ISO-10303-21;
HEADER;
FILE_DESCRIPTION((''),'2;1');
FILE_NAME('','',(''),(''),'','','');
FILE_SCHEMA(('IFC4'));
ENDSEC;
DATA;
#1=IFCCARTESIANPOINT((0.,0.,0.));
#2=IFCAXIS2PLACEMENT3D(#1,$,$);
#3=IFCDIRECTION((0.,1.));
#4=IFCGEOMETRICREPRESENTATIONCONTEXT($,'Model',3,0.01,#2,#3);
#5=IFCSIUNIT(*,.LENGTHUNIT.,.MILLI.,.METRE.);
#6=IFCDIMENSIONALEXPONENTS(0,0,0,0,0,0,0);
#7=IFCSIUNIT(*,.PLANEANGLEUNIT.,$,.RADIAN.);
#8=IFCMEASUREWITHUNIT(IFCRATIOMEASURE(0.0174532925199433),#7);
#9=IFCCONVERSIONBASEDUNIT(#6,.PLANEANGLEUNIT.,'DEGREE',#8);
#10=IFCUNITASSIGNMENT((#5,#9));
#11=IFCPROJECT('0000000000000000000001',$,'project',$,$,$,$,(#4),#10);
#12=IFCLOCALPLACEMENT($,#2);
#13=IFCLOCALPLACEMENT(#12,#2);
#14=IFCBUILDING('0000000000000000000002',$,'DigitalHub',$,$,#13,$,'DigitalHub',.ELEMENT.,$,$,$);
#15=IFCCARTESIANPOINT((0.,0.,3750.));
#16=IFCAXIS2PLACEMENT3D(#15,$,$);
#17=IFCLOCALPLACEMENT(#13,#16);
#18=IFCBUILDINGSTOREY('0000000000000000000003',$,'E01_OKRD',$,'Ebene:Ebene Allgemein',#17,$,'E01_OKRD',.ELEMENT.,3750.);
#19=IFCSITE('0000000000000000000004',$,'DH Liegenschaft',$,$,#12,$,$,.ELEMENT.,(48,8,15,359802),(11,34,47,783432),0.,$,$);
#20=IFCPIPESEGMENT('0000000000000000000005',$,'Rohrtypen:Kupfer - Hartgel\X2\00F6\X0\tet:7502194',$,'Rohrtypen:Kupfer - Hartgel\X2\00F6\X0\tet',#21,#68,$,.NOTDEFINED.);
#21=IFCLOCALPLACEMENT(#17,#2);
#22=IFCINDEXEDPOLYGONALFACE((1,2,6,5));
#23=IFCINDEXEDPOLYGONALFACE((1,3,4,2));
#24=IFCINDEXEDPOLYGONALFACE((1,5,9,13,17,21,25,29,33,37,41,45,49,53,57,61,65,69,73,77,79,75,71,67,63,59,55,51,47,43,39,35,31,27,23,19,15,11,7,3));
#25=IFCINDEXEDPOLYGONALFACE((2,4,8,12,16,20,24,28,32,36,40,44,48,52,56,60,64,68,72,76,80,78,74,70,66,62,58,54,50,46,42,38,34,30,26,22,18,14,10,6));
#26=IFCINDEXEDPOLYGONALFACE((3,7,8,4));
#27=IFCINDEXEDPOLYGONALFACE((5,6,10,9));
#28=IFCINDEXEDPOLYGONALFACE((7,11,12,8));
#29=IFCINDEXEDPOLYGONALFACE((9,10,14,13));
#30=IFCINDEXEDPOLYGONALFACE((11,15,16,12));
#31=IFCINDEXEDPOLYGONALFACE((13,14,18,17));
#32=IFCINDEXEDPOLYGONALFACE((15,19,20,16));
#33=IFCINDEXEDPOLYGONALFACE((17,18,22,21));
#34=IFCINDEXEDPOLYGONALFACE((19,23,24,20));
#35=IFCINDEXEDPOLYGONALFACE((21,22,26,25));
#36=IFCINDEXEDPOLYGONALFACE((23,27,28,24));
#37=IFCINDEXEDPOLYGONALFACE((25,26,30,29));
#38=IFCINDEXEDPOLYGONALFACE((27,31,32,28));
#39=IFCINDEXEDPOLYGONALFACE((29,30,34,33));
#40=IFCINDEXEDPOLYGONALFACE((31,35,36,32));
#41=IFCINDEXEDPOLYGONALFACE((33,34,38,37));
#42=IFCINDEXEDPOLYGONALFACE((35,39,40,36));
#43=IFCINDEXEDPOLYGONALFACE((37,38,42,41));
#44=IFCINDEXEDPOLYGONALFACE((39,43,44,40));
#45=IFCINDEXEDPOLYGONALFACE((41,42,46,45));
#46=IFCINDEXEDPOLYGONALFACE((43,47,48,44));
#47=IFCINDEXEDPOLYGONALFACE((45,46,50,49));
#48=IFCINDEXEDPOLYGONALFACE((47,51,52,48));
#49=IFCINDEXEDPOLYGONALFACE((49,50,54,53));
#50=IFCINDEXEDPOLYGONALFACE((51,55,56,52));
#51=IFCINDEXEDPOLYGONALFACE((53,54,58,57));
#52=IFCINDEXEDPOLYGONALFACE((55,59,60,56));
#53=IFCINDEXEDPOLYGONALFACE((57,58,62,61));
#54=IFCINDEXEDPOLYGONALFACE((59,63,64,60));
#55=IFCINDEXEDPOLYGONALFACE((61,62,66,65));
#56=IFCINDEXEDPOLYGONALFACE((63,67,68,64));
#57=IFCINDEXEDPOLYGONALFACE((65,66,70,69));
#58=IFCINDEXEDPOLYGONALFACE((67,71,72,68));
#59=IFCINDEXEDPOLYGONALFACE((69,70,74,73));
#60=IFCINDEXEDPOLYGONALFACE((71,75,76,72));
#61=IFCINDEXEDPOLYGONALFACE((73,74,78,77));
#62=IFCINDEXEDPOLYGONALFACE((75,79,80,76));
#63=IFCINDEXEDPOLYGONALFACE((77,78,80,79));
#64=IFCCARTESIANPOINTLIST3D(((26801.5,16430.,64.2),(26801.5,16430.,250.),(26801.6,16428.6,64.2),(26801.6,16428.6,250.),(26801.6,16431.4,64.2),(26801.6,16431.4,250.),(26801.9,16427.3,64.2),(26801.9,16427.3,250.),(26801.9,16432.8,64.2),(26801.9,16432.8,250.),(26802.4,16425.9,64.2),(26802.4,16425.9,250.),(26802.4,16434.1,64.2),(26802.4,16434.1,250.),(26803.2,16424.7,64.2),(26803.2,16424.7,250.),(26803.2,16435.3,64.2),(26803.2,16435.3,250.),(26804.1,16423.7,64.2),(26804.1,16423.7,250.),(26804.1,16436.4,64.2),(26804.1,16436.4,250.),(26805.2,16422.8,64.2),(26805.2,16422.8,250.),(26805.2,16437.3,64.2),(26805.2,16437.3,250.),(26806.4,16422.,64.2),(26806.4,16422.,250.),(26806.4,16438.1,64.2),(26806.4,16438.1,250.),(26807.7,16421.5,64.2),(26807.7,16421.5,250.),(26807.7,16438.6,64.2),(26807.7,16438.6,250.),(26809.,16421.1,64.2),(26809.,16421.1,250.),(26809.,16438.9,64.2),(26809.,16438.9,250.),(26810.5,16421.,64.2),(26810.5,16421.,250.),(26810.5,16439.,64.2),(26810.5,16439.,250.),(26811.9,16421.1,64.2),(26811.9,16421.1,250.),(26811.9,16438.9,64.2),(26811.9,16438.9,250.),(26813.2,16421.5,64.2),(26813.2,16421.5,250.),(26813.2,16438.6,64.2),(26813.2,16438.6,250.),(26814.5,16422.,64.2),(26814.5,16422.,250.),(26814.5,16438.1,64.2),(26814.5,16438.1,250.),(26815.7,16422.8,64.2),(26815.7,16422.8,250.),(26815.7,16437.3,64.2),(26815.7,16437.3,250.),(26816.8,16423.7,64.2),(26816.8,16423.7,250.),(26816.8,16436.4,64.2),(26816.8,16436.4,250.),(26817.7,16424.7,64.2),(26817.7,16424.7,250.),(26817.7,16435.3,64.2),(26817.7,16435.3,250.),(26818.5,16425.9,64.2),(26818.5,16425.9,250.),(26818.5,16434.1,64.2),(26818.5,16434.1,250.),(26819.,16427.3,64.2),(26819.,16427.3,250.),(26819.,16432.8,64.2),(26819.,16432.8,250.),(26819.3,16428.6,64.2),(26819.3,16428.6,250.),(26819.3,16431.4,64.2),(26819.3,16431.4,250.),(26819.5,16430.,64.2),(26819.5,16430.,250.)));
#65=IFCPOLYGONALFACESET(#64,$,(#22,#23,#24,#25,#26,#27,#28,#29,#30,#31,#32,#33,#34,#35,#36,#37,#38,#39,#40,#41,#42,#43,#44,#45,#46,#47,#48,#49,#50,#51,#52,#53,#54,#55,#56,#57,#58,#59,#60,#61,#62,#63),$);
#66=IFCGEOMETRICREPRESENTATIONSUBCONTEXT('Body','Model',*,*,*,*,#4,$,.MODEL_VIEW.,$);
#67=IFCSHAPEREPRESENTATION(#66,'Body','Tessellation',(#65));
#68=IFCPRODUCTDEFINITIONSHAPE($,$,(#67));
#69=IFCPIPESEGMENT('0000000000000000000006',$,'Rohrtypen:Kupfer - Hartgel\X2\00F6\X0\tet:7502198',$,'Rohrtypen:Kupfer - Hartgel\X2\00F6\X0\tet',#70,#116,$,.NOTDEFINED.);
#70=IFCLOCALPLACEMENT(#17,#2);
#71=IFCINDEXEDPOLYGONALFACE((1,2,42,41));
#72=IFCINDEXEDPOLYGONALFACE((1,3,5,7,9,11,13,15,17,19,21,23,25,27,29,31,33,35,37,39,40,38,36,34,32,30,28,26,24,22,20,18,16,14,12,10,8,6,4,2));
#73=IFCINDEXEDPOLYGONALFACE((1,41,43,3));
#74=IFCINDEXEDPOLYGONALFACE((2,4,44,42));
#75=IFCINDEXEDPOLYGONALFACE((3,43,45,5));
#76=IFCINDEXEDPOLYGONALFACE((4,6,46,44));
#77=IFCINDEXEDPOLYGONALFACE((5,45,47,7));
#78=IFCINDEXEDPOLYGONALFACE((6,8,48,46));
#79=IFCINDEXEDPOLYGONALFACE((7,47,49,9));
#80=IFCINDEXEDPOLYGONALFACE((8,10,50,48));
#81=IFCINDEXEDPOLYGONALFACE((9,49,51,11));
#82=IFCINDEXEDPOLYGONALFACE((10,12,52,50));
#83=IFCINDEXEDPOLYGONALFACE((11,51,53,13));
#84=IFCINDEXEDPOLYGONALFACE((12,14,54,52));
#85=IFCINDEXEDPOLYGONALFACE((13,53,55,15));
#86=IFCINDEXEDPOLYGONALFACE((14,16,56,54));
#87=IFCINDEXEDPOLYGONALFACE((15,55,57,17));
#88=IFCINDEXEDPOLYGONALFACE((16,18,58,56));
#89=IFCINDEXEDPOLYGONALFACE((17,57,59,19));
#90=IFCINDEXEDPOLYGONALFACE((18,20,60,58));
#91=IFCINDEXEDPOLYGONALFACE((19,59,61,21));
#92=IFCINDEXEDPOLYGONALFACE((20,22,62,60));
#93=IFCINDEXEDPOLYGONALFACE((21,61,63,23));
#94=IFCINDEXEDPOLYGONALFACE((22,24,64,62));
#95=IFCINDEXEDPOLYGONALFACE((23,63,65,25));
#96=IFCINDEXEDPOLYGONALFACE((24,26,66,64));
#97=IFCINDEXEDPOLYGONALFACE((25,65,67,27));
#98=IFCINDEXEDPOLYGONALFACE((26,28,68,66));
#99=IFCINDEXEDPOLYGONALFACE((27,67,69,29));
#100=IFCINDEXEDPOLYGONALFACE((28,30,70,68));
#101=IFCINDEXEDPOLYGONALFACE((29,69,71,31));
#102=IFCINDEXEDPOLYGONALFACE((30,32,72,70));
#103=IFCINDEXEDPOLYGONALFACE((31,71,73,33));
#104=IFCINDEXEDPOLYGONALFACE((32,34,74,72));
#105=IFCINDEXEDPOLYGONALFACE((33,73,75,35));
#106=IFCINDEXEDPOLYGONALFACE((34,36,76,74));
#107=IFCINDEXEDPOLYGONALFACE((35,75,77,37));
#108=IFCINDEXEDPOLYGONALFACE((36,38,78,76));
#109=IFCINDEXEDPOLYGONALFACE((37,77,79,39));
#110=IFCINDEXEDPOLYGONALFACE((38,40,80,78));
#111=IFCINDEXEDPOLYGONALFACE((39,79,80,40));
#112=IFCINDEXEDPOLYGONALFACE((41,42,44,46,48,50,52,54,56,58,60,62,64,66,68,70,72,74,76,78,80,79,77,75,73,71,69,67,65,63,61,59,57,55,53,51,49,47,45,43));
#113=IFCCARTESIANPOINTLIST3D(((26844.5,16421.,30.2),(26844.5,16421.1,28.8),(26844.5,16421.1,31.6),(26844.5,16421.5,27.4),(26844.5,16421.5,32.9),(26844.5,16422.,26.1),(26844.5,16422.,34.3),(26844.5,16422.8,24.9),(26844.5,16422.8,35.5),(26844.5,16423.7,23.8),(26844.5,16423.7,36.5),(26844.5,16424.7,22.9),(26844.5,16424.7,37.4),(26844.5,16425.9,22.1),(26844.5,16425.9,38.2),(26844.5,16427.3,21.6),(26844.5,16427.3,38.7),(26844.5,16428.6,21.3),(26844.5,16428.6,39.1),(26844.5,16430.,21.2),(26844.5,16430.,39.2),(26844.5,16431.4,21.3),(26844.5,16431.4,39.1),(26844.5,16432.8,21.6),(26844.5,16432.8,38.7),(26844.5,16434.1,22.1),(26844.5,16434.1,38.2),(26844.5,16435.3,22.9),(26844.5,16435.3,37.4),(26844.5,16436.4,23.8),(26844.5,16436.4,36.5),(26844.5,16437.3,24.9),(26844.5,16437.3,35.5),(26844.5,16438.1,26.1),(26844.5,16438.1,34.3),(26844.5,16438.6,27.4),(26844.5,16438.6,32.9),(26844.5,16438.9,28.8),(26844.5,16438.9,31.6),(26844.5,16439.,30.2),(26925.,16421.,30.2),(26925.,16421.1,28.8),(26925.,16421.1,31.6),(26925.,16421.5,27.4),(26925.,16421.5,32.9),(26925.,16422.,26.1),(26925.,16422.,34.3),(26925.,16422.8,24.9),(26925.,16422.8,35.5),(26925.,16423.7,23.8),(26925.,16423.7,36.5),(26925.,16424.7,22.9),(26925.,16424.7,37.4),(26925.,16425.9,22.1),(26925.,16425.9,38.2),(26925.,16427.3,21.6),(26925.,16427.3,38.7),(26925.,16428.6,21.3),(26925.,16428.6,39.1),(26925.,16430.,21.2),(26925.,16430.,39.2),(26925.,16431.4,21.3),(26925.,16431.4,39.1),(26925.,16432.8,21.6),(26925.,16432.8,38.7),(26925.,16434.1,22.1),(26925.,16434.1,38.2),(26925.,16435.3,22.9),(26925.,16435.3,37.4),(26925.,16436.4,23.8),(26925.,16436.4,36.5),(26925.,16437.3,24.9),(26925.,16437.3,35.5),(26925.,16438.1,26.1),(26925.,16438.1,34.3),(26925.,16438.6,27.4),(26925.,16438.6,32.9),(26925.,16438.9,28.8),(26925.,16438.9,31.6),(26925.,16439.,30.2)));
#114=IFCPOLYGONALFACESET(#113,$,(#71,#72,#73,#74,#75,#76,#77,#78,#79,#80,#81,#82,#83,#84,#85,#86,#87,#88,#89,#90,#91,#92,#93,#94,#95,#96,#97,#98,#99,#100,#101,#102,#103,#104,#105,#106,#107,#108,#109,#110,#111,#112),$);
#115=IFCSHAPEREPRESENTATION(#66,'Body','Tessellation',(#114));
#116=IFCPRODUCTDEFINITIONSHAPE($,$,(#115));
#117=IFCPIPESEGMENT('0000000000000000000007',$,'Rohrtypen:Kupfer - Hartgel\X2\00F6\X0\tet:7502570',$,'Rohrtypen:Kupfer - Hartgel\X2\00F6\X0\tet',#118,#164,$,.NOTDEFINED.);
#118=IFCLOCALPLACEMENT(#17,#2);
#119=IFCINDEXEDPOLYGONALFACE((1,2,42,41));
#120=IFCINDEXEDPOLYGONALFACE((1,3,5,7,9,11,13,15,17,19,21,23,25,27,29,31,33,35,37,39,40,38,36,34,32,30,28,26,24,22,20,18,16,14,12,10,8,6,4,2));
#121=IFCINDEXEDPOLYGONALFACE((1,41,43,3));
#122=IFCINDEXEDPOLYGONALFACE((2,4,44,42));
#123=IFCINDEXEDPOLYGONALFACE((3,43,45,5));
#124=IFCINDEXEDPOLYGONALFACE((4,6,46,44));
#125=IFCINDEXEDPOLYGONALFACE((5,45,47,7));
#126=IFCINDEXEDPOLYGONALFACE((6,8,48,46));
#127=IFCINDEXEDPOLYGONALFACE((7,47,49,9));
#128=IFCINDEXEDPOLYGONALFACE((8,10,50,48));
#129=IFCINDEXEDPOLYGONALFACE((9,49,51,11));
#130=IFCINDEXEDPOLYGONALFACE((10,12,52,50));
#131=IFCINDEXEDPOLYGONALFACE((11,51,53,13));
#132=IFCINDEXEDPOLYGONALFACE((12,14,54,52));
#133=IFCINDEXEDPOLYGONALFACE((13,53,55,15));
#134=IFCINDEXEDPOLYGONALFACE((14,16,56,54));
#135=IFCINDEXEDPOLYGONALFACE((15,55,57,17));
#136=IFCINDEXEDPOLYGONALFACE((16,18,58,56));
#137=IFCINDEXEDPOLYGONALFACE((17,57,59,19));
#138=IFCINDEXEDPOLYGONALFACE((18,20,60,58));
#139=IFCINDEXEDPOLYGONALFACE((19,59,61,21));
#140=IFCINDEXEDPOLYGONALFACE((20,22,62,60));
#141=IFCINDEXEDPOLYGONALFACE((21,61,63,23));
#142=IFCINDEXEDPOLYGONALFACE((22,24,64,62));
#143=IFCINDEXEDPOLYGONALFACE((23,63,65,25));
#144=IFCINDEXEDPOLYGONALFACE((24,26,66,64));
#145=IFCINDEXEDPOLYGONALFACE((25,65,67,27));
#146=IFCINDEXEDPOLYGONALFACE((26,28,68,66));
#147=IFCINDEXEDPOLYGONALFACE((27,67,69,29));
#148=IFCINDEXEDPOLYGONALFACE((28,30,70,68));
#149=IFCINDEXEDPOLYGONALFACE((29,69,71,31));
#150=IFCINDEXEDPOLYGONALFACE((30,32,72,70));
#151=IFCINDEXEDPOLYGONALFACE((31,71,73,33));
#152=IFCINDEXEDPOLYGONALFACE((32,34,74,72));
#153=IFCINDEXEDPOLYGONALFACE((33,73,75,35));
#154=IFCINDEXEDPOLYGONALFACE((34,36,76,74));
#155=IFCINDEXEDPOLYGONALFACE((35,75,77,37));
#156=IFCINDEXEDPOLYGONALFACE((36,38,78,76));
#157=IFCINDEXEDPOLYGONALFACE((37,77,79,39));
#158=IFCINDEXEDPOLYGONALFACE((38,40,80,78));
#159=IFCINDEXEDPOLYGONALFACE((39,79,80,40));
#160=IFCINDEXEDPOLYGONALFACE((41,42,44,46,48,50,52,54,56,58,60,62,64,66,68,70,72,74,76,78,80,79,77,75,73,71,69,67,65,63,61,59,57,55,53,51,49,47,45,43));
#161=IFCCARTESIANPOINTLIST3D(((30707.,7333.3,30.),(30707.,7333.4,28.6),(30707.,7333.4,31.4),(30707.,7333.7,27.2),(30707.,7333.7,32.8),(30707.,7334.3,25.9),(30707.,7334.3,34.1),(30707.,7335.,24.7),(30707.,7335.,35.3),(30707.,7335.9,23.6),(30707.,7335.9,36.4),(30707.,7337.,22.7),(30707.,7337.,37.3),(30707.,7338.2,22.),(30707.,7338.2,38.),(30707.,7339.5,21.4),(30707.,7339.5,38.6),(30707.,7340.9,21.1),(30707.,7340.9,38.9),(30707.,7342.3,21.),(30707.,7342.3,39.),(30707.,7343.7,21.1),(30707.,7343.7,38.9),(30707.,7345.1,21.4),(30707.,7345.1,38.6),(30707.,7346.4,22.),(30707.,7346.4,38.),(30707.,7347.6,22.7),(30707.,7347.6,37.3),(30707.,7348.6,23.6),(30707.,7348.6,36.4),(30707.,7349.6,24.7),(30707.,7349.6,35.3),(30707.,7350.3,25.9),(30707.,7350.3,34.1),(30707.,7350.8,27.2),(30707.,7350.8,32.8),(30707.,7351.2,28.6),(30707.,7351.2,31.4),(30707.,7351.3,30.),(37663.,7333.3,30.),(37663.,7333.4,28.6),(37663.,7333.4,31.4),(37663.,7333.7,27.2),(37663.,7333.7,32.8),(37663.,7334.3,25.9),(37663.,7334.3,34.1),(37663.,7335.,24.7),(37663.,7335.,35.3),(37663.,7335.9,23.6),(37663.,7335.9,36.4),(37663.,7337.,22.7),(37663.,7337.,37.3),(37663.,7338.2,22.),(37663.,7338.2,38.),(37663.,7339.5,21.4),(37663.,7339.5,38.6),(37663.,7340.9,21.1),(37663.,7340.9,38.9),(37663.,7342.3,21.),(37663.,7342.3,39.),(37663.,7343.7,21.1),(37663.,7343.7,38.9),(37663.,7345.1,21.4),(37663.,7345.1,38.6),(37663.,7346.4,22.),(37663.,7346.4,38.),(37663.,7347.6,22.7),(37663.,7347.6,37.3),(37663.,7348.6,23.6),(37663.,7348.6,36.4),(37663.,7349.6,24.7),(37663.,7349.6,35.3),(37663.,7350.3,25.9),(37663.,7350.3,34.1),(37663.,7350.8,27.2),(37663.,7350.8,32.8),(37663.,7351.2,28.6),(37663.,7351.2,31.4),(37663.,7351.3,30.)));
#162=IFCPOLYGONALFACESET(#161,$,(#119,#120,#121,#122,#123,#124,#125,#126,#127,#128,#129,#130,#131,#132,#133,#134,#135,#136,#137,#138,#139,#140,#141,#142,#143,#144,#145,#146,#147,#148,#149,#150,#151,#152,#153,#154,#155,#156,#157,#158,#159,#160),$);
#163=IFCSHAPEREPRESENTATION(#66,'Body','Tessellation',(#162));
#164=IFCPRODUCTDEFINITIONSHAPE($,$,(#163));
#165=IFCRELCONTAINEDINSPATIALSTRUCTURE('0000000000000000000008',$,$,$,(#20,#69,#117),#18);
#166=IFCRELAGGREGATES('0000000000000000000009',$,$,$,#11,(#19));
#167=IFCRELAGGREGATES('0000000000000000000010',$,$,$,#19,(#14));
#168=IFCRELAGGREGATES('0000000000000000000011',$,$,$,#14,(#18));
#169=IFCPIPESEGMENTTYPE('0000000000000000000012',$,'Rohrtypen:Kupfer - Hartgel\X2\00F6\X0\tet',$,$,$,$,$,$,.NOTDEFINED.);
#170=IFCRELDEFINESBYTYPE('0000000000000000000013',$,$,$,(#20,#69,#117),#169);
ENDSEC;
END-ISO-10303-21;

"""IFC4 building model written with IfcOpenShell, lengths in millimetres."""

from ifc_helpers import new_model, entity, si_unit, converted_unit, direction, frame, origin, place, context, subcontext, project, spatial, indexed_curve, outline, extrude, type_object, element, save


model = new_model("IFC4")

# Units and contexts
model_context = context("Model", 3, precision=0.01, world=origin(), true_north=direction((0.0, 1.0)))
body_context = subcontext(model_context, "Body", "Model", "MODEL_VIEW")
ifc_project = project(units=[si_unit("LENGTHUNIT", "METRE", prefix="MILLI"), converted_unit("PLANEANGLEUNIT", "DEGREE", entity("IfcRatioMeasure", 0.0174532925199433), si_unit("PLANEANGLEUNIT", "RADIAN"), dimensions=[0, 0, 0, 0, 0, 0, 0])], contexts=[model_context])

# Site, building, storey
site_placement = place(None, origin())
site = spatial("IfcSite", under=ifc_project, at=site_placement, Name="DH Liegenschaft", CompositionType="ELEMENT", RefLatitude=(48, 8, 15, 359802), RefLongitude=(11, 34, 47, 783432), RefElevation=0.0)
building_placement = place(site_placement, origin())
building = spatial("IfcBuilding", under=site, at=building_placement, Name="DigitalHub", LongName="DigitalHub", CompositionType="ELEMENT")
storey_placement = place(building_placement, frame((0.0, 0.0, 3750.0)))
storey = spatial("IfcBuildingStorey", under=building, at=storey_placement, Name="E01_OKRD", ObjectType="Ebene:Ebene Allgemein", LongName="E01_OKRD", CompositionType="ELEMENT", Elevation=3750.0)

# Pipe segments
pipe_segment_type = type_object("IfcPipeSegmentType", Name="Rohrtypen:Kupfer - Hartgelötet", PredefinedType="NOTDEFINED")
pipe_segment_1_placement = place(storey_placement, frame((26799.9, 16419.4, 64.2)))
element("IfcPipeSegment", 1, at=pipe_segment_1_placement, inside=storey, type_object=pipe_segment_type, Name="Rohrtypen:Kupfer - Hartgelötet:7502194", ObjectType="Rohrtypen:Kupfer - Hartgelötet", PredefinedType="NOTDEFINED", context=body_context, shape_type="SweptSolid", body=[
    extrude(outline(indexed_curve([(9.0, 0.0), (8.9, 1.4), (8.6, 2.8), (8.0, 4.1), (7.3, 5.3), (6.4, 6.4), (5.3, 7.3), (4.1, 8.0), (2.8, 8.6), (1.4, 8.9), (0.0, 9.0), (-1.4, 8.9), (-2.8, 8.6), (-4.1, 8.0), (-5.3, 7.3), (-6.4, 6.4), (-7.3, 5.3), (-8.0, 4.1), (-8.6, 2.8), (-8.9, 1.4), (-9.0, 0.0), (-8.9, -1.4), (-8.6, -2.8), (-8.0, -4.1), (-7.3, -5.3), (-6.4, -6.4), (-5.3, -7.3), (-4.1, -8.0), (-2.8, -8.6), (-1.4, -8.9), (0.0, -9.0), (1.4, -8.9), (2.8, -8.6), (4.1, -8.0), (5.3, -7.3), (6.4, -6.4), (7.3, -5.3), (8.0, -4.1), (8.6, -2.8), (8.9, -1.4), (9.0, 0.0)], self_intersect=False)), frame((10.6, 10.6, 0.0)), (0.0, 0.0, 1.0), 185.8),
])
pipe_segment_2_placement = place(storey_placement, frame((26844.5, 16419.4, 19.6)))
element("IfcPipeSegment", 2, at=pipe_segment_2_placement, inside=storey, type_object=pipe_segment_type, Name="Rohrtypen:Kupfer - Hartgelötet:7502198", ObjectType="Rohrtypen:Kupfer - Hartgelötet", PredefinedType="NOTDEFINED", context=body_context, shape_type="SweptSolid", body=[
    extrude(outline(indexed_curve([(9.0, 0.0), (8.9, 1.4), (8.6, 2.8), (8.0, 4.1), (7.3, 5.3), (6.4, 6.4), (5.3, 7.3), (4.1, 8.0), (2.8, 8.6), (1.4, 8.9), (0.0, 9.0), (-1.4, 8.9), (-2.8, 8.6), (-4.1, 8.0), (-5.3, 7.3), (-6.4, 6.4), (-7.3, 5.3), (-8.0, 4.1), (-8.6, 2.8), (-8.9, 1.4), (-9.0, 0.0), (-8.9, -1.4), (-8.6, -2.8), (-8.0, -4.1), (-7.3, -5.3), (-6.4, -6.4), (-5.3, -7.3), (-4.1, -8.0), (-2.8, -8.6), (-1.4, -8.9), (0.0, -9.0), (1.4, -8.9), (2.8, -8.6), (4.1, -8.0), (5.3, -7.3), (6.4, -6.4), (7.3, -5.3), (8.0, -4.1), (8.6, -2.8), (8.9, -1.4), (9.0, 0.0)], self_intersect=False)), frame((0.0, 10.6, 10.6), z_axis=(1.0, 0.0, 0.0), x_axis=(0.0, -1.0, 0.0)), (0.0, 0.0, 1.0), 80.5),
])
pipe_segment_3_placement = place(storey_placement, frame((30707.0, 7331.7, 19.4)))
element("IfcPipeSegment", 3, at=pipe_segment_3_placement, inside=storey, type_object=pipe_segment_type, Name="Rohrtypen:Kupfer - Hartgelötet:7502570", ObjectType="Rohrtypen:Kupfer - Hartgelötet", PredefinedType="NOTDEFINED", context=body_context, shape_type="SweptSolid", body=[
    extrude(outline(indexed_curve([(9.0, 0.0), (8.9, 1.4), (8.6, 2.8), (8.0, 4.1), (7.3, 5.3), (6.4, 6.4), (5.3, 7.3), (4.1, 8.0), (2.8, 8.6), (1.4, 8.9), (0.0, 9.0), (-1.4, 8.9), (-2.8, 8.6), (-4.1, 8.0), (-5.3, 7.3), (-6.4, 6.4), (-7.3, 5.3), (-8.0, 4.1), (-8.6, 2.8), (-8.9, 1.4), (-9.0, 0.0), (-8.9, -1.4), (-8.6, -2.8), (-8.0, -4.1), (-7.3, -5.3), (-6.4, -6.4), (-5.3, -7.3), (-4.1, -8.0), (-2.8, -8.6), (-1.4, -8.9), (0.0, -9.0), (1.4, -8.9), (2.8, -8.6), (4.1, -8.0), (5.3, -7.3), (6.4, -6.4), (7.3, -5.3), (8.0, -4.1), (8.6, -2.8), (8.9, -1.4), (9.0, 0.0)], self_intersect=False)), frame((0.0, 10.6, 10.6), z_axis=(1.0, 0.0, 0.0), x_axis=(0.0, -1.0, 0.0)), (0.0, 0.0, 1.0), 6956.0),
])

save(model, "model.ifc")
